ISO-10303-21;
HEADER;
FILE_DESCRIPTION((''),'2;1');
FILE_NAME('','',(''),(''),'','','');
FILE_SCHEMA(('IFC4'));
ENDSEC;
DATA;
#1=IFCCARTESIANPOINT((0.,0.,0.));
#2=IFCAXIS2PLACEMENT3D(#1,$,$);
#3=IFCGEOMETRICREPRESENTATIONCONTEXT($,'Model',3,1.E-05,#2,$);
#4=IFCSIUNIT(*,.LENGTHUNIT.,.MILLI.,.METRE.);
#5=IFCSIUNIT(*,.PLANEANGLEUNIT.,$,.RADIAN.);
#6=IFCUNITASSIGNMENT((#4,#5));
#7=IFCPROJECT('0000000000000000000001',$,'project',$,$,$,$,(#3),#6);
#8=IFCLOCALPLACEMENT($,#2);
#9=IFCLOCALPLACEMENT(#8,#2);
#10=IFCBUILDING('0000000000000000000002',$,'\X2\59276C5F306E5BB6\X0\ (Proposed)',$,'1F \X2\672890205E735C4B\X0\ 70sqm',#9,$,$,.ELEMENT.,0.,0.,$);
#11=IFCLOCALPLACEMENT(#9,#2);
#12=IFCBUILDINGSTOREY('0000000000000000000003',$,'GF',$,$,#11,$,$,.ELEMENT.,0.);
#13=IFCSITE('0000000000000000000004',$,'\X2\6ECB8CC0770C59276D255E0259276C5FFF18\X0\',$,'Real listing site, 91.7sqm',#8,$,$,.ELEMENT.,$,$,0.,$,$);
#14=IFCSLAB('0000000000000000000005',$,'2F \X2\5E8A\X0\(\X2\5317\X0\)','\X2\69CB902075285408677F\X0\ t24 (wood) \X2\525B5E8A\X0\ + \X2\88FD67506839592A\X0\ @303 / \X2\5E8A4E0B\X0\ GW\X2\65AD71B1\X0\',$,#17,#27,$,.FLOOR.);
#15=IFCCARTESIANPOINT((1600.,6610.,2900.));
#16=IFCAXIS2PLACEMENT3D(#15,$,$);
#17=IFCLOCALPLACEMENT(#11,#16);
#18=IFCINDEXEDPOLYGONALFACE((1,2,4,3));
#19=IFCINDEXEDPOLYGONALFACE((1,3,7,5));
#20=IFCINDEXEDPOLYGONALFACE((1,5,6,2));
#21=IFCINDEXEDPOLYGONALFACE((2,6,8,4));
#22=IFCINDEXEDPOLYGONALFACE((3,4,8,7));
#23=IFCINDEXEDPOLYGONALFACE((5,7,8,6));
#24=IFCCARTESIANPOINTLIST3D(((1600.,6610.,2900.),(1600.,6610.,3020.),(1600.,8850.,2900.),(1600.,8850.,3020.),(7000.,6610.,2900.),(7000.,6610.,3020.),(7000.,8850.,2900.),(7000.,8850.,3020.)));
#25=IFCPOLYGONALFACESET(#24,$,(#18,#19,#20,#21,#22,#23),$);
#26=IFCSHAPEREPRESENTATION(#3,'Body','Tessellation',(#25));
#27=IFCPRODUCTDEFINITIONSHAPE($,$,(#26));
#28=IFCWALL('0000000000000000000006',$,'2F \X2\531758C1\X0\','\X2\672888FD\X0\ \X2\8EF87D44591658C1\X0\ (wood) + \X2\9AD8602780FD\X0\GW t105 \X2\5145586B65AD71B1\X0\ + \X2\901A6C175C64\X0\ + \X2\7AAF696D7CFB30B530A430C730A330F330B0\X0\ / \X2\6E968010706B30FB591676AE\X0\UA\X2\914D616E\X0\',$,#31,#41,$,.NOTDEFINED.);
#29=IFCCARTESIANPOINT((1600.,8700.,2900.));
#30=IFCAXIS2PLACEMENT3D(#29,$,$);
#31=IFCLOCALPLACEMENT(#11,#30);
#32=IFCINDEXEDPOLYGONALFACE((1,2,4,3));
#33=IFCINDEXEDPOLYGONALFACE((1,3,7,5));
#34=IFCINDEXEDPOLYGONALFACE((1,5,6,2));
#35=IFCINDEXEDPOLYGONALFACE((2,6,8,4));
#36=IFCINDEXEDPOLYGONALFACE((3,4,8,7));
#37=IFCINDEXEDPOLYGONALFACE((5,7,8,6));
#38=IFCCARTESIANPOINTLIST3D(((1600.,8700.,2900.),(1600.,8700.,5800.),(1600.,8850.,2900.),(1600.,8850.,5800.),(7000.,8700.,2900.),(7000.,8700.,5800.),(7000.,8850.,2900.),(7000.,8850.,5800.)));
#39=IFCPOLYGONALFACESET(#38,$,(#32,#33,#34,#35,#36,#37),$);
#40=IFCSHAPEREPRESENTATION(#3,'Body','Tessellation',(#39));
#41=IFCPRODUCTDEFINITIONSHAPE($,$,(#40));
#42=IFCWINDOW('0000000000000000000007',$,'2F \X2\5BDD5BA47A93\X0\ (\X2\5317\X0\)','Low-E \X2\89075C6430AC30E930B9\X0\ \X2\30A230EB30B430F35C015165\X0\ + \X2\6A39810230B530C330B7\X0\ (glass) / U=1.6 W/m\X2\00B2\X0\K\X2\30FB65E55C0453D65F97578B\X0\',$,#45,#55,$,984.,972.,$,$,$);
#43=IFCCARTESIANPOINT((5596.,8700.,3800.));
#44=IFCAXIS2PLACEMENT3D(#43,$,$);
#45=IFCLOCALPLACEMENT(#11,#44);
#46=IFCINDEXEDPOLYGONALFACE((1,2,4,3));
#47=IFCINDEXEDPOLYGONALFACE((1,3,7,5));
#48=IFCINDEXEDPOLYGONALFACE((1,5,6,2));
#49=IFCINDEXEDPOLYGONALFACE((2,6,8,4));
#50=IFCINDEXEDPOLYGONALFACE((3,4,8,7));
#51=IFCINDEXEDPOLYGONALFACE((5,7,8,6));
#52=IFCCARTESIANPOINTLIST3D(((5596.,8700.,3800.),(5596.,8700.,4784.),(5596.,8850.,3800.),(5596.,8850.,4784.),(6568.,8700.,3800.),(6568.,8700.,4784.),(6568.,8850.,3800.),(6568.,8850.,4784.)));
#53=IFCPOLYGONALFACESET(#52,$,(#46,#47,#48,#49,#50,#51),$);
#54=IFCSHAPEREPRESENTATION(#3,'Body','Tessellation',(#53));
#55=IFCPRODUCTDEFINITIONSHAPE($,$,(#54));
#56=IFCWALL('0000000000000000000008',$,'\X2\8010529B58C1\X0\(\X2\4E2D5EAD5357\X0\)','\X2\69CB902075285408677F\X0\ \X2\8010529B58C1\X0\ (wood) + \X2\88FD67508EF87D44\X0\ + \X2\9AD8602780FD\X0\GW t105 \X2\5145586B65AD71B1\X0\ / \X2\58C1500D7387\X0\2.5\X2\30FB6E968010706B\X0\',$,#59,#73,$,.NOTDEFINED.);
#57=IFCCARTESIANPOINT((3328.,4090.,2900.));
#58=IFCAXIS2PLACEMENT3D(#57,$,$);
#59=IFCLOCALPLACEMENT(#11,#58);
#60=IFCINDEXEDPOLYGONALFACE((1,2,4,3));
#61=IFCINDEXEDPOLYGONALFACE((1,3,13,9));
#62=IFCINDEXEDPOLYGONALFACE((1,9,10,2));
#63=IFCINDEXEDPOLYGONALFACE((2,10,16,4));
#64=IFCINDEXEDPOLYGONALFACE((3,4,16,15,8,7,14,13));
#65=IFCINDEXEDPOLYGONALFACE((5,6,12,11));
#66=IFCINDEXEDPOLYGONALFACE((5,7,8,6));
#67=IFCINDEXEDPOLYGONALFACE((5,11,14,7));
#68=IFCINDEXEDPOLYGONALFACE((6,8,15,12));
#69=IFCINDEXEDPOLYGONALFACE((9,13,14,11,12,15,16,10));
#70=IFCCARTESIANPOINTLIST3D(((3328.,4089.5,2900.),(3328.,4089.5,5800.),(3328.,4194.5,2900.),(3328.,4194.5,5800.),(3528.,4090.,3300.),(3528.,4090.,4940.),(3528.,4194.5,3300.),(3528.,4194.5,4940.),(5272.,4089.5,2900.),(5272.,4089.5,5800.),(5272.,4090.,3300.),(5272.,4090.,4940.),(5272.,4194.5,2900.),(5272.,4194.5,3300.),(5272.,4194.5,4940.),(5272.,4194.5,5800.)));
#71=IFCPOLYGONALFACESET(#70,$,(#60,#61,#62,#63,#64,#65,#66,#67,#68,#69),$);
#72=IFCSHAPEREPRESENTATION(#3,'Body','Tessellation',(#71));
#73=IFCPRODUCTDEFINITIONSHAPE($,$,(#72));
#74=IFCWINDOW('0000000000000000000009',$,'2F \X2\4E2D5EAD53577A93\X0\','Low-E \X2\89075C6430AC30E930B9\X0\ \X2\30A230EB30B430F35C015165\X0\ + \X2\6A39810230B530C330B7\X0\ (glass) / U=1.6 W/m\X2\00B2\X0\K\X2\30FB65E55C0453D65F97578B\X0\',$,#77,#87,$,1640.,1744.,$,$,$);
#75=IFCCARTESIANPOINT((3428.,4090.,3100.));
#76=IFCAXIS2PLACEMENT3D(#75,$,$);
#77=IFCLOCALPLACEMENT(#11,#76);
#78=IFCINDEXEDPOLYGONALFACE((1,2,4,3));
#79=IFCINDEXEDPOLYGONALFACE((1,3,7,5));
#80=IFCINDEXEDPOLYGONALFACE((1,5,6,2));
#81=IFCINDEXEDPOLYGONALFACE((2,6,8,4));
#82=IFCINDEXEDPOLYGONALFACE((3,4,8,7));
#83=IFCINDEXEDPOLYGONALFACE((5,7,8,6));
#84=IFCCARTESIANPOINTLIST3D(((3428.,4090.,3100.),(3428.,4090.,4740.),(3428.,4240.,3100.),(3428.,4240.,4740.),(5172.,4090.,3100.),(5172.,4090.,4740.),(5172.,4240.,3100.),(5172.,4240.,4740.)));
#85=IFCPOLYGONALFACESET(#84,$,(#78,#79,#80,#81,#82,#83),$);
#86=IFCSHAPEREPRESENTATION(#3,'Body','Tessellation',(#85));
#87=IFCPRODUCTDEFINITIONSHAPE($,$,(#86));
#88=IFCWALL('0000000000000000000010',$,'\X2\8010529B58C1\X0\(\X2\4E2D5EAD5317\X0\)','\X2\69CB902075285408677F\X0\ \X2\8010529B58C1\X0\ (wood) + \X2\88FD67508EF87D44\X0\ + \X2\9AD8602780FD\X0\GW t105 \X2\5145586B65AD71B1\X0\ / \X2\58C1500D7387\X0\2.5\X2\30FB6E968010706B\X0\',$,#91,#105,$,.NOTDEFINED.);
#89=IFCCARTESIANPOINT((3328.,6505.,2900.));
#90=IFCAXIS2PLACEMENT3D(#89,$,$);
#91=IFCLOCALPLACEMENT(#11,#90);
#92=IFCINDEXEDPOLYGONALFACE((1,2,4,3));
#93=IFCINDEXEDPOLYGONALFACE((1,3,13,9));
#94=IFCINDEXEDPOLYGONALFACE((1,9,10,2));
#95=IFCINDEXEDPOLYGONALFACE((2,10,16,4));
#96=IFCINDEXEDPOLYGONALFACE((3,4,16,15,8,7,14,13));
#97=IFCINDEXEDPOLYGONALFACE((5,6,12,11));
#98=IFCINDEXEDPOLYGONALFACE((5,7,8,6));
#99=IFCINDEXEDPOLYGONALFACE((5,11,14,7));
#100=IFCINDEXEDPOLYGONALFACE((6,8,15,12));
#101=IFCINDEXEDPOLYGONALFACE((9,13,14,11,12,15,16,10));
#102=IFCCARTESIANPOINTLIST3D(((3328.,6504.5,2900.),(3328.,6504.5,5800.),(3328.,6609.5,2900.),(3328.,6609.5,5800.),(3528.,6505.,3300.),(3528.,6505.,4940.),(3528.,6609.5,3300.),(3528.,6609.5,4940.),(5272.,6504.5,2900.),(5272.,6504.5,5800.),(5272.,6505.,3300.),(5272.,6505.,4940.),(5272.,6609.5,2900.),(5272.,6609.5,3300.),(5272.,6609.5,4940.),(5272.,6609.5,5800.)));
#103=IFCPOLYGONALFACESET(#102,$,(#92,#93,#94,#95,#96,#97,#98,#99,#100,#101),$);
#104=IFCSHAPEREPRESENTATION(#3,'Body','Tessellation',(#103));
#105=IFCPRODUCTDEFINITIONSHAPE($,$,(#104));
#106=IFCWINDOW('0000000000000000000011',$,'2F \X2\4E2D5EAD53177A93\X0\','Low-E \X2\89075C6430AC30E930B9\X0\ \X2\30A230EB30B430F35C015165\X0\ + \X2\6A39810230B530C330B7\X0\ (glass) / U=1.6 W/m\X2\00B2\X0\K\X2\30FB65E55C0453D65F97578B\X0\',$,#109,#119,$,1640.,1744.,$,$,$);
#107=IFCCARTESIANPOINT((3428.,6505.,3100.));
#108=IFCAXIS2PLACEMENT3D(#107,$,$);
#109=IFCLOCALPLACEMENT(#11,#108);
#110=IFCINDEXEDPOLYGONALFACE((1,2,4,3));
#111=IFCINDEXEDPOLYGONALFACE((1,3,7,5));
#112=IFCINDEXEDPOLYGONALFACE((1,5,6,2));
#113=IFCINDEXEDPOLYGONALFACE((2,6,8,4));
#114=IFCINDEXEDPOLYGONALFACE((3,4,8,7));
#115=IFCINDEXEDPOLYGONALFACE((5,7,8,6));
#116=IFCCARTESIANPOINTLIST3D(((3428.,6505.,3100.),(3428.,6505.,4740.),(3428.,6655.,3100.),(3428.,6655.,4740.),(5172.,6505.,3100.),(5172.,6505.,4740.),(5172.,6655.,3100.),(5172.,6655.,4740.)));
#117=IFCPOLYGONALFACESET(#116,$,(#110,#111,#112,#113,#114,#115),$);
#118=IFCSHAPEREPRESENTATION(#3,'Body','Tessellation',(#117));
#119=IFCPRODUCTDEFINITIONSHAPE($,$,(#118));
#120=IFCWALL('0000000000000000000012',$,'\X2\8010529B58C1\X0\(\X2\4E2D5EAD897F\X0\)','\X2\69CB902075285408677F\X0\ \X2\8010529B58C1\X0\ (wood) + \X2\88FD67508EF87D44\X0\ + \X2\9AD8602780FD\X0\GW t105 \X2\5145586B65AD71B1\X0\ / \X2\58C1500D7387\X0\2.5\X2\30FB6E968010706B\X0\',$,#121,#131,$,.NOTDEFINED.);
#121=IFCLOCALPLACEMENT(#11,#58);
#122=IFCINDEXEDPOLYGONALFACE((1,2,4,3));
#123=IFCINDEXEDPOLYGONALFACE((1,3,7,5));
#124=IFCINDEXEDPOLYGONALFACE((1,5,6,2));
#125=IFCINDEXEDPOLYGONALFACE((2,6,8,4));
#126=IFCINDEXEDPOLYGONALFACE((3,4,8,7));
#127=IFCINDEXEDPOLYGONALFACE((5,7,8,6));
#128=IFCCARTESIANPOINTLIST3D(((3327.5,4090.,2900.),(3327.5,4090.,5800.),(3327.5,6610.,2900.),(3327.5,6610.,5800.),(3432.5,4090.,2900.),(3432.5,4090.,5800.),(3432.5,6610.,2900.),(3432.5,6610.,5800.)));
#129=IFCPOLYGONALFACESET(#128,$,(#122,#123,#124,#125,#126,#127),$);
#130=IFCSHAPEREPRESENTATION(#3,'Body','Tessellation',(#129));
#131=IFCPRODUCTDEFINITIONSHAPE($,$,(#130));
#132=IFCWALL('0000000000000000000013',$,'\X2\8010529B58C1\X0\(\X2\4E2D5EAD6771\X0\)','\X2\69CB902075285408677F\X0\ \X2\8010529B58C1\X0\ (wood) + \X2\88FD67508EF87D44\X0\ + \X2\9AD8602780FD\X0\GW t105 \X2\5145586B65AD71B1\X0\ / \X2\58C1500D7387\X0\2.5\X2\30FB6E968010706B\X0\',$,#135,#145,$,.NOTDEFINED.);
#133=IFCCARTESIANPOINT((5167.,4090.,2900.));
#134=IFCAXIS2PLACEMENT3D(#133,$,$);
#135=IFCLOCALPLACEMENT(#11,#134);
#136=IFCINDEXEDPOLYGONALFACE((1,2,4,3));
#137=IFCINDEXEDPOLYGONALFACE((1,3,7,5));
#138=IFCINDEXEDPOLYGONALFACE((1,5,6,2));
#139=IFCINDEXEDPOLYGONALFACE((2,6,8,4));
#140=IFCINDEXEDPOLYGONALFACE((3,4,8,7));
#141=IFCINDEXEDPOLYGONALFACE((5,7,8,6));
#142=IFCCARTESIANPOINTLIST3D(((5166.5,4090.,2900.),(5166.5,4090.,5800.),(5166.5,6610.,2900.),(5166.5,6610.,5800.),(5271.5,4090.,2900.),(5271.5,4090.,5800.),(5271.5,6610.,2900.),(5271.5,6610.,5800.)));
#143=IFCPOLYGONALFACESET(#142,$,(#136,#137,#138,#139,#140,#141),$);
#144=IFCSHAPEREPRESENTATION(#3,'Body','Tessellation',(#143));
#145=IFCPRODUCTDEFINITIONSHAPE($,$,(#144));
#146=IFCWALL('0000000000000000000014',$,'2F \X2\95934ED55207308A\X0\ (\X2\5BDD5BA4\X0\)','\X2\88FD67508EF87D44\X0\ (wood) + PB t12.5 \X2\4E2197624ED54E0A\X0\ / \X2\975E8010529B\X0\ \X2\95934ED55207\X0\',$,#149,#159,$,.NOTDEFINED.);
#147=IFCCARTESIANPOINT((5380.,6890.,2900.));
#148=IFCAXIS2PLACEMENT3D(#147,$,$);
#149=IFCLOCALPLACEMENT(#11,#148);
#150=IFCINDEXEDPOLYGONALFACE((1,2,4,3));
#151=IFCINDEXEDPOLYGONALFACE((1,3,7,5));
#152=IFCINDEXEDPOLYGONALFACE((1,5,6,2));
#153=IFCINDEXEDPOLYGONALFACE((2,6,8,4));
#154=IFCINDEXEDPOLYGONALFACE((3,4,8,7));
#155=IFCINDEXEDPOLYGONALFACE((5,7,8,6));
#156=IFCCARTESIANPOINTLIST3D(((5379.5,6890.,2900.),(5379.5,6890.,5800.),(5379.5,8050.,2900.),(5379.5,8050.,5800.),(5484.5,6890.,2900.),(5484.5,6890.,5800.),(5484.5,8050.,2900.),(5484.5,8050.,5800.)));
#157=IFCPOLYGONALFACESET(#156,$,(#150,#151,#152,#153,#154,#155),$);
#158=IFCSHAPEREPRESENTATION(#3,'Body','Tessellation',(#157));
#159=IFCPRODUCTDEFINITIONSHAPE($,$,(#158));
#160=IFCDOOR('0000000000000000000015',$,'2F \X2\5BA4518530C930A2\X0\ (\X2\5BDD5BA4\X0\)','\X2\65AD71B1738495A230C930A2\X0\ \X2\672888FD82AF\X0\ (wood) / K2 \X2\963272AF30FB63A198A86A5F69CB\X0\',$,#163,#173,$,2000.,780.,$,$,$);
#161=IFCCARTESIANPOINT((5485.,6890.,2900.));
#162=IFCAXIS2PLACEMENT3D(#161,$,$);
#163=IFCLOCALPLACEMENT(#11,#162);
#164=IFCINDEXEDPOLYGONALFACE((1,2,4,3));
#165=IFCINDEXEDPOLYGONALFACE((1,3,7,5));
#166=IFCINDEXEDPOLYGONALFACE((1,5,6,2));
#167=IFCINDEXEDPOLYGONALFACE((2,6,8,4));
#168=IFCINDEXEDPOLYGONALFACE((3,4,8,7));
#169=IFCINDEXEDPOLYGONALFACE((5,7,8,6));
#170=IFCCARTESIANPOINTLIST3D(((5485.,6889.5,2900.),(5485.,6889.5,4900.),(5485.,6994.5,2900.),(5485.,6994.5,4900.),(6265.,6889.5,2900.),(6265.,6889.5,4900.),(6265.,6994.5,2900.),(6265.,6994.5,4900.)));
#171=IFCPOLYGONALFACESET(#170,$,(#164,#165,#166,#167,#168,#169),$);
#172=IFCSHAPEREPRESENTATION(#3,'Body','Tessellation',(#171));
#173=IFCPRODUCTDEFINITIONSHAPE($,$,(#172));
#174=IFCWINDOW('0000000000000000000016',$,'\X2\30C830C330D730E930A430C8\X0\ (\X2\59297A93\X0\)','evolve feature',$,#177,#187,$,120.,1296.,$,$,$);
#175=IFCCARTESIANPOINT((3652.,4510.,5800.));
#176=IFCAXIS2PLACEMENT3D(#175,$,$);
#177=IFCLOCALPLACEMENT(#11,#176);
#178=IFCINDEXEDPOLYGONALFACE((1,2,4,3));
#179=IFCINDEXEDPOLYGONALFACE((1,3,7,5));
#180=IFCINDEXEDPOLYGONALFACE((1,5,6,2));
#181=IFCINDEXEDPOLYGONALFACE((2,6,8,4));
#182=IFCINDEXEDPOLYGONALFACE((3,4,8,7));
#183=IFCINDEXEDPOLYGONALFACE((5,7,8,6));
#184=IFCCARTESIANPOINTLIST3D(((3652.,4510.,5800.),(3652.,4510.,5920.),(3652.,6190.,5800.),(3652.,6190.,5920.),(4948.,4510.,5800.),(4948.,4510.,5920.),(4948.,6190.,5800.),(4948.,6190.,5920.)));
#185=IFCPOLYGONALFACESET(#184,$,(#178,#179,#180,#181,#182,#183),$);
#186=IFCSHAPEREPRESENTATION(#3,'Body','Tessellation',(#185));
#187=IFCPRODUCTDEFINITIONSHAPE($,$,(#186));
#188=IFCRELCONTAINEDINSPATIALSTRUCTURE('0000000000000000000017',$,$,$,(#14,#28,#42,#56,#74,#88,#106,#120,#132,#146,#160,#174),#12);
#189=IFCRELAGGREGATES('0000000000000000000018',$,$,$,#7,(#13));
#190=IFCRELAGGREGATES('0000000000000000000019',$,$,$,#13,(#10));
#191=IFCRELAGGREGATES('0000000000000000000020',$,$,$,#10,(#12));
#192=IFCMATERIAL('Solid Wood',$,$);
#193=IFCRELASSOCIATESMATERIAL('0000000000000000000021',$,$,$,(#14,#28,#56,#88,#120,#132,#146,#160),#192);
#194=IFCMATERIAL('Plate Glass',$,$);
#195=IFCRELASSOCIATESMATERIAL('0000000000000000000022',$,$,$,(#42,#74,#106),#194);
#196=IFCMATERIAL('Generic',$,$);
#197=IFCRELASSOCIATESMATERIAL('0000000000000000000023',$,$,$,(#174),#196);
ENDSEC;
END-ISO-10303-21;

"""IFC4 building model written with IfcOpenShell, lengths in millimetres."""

from ifc_helpers import new_model, si_unit, frame, frame_2d, origin, place, context, project, spatial, rectangle, extrude, material, element, fill, save


model = new_model("IFC4")

# Units and contexts
model_context = context("Model", 3, precision=1e-05, world=origin())
ifc_project = project(units=[si_unit("LENGTHUNIT", "METRE", prefix="MILLI"), si_unit("PLANEANGLEUNIT", "RADIAN")], contexts=[model_context])

# Site, building, storey
site_placement = place(None, origin())
site = spatial("IfcSite", under=ifc_project, at=site_placement, Name="滋賀県大津市大江８", ObjectType="Real listing site, 91.7sqm", CompositionType="ELEMENT", RefElevation=0.0)
building_placement = place(site_placement, origin())
building = spatial("IfcBuilding", under=site, at=building_placement, Name="大江の家 (Proposed)", ObjectType="1F 木造平屋 70sqm", CompositionType="ELEMENT", ElevationOfRefHeight=0.0, ElevationOfTerrain=0.0)
storey_placement = place(building_placement, origin())
storey = spatial("IfcBuildingStorey", under=building, at=storey_placement, Name="GF", CompositionType="ELEMENT", Elevation=0.0)

# Slab
ifc_material_1 = material(Name="Solid Wood")
slab_placement = place(storey_placement, frame((1600.0, 6610.0, 2900.0)))
element("IfcSlab", 1, at=slab_placement, inside=storey, material=ifc_material_1, Name="2F 床(北)", Description="構造用合板 t24 (wood) 剛床 + 製材根太 @303 / 床下 GW断熱", PredefinedType="FLOOR", context=model_context, shape_type="SweptSolid", body=[
    extrude(rectangle(XDim=5400.0, YDim=2240.0, at=frame_2d((2700.0, 1120.0))), frame((1600.0, 6610.0, 2900.0)), (0.0, 0.0, 1.0), 120.0),
])

# Walls, openings, windows
wall_1_placement = place(storey_placement, frame((1600.0, 8700.0, 2900.0)))
wall_1 = element("IfcWall", 2, at=wall_1_placement, inside=storey, material=ifc_material_1, Name="2F 北壁", Description="木製 軸組外壁 (wood) + 高性能GW t105 充填断熱 + 通気層 + 窯業系サイディング / 準耐火・外皮UA配慮", PredefinedType="NOTDEFINED", context=model_context, shape_type="SweptSolid", body=[
    extrude(rectangle(XDim=5400.0, YDim=150.0, at=frame_2d((2700.0, 75.0))), frame((1600.0, 8700.0, 2900.0)), (0.0, 0.0, 1.0), 2900.0),
])
opening_1_placement = place(storey_placement, frame((5596.0, 8700.0, 3800.0)))
opening_1 = element("IfcOpeningElement", 3, at=opening_1_placement, cuts=wall_1, PredefinedType="NOTDEFINED", context=model_context, shape_type="SweptSolid", body=[
    extrude(rectangle(XDim=972.0, YDim=150.0, at=frame_2d((486.0, 75.0))), frame((5596.0, 8700.0, 3800.0)), (0.0, 0.0, 1.0), 984.0),
])
ifc_material_2 = material(Name="Plate Glass")
window_1_placement = place(storey_placement, frame((5596.0, 8700.0, 3800.0)))
window_1 = element("IfcWindow", 4, at=window_1_placement, inside=storey, material=ifc_material_2, Name="2F 寝室窓 (北)", Description="Low-E 複層ガラス アルゴン封入 + 樹脂サッシ (glass) / U=1.6 W/m²K・日射取得型", OverallHeight=984.0, OverallWidth=972.0, context=model_context, shape_type="SweptSolid", body=[
    extrude(rectangle(XDim=972.0, YDim=150.0, at=frame_2d((486.0, 75.0))), frame((5596.0, 8700.0, 3800.0)), (0.0, 0.0, 1.0), 984.0),
])
fill(opening_1, window_1)
wall_2_placement = place(storey_placement, frame((3328.0, 4090.0, 2900.0)))
wall_2 = element("IfcWall", 5, at=wall_2_placement, inside=storey, material=ifc_material_1, Name="耐力壁(中庭南)", Description="構造用合板 耐力壁 (wood) + 製材軸組 + 高性能GW t105 充填断熱 / 壁倍率2.5・準耐火", PredefinedType="NOTDEFINED", context=model_context, shape_type="SweptSolid", body=[
    extrude(rectangle(XDim=1944.0, YDim=105.0, at=frame_2d((972.0, 52.0))), frame((3328.0, 4090.0, 2900.0)), (0.0, 0.0, 1.0), 2900.0),
])
opening_2_placement = place(storey_placement, frame((3428.0, 4090.0, 3100.0)))
opening_2 = element("IfcOpeningElement", 6, at=opening_2_placement, cuts=wall_2, PredefinedType="NOTDEFINED", context=model_context, shape_type="SweptSolid", body=[
    extrude(rectangle(XDim=1744.0, YDim=150.0, at=frame_2d((872.0, 75.0))), frame((3428.0, 4090.0, 3100.0)), (0.0, 0.0, 1.0), 1640.0),
])
window_2_placement = place(storey_placement, frame((3428.0, 4090.0, 3100.0)))
window_2 = element("IfcWindow", 7, at=window_2_placement, inside=storey, material=ifc_material_2, Name="2F 中庭南窓", Description="Low-E 複層ガラス アルゴン封入 + 樹脂サッシ (glass) / U=1.6 W/m²K・日射取得型", OverallHeight=1640.0, OverallWidth=1744.0, context=model_context, shape_type="SweptSolid", body=[
    extrude(rectangle(XDim=1744.0, YDim=150.0, at=frame_2d((872.0, 75.0))), frame((3428.0, 4090.0, 3100.0)), (0.0, 0.0, 1.0), 1640.0),
])
fill(opening_2, window_2)
wall_3_placement = place(storey_placement, frame((3328.0, 6505.0, 2900.0)))
wall_3 = element("IfcWall", 8, at=wall_3_placement, inside=storey, material=ifc_material_1, Name="耐力壁(中庭北)", Description="構造用合板 耐力壁 (wood) + 製材軸組 + 高性能GW t105 充填断熱 / 壁倍率2.5・準耐火", PredefinedType="NOTDEFINED", context=model_context, shape_type="SweptSolid", body=[
    extrude(rectangle(XDim=1944.0, YDim=105.0, at=frame_2d((972.0, 52.0))), frame((3328.0, 6505.0, 2900.0)), (0.0, 0.0, 1.0), 2900.0),
])
opening_3_placement = place(storey_placement, frame((3428.0, 6505.0, 3100.0)))
opening_3 = element("IfcOpeningElement", 9, at=opening_3_placement, cuts=wall_3, PredefinedType="NOTDEFINED", context=model_context, shape_type="SweptSolid", body=[
    extrude(rectangle(XDim=1744.0, YDim=150.0, at=frame_2d((872.0, 75.0))), frame((3428.0, 6505.0, 3100.0)), (0.0, 0.0, 1.0), 1640.0),
])
window_3_placement = place(storey_placement, frame((3428.0, 6505.0, 3100.0)))
window_3 = element("IfcWindow", 10, at=window_3_placement, inside=storey, material=ifc_material_2, Name="2F 中庭北窓", Description="Low-E 複層ガラス アルゴン封入 + 樹脂サッシ (glass) / U=1.6 W/m²K・日射取得型", OverallHeight=1640.0, OverallWidth=1744.0, context=model_context, shape_type="SweptSolid", body=[
    extrude(rectangle(XDim=1744.0, YDim=150.0, at=frame_2d((872.0, 75.0))), frame((3428.0, 6505.0, 3100.0)), (0.0, 0.0, 1.0), 1640.0),
])
fill(opening_3, window_3)

# Walls
wall_4_placement = place(storey_placement, frame((3328.0, 4090.0, 2900.0)))
element("IfcWall", 11, at=wall_4_placement, inside=storey, material=ifc_material_1, Name="耐力壁(中庭西)", Description="構造用合板 耐力壁 (wood) + 製材軸組 + 高性能GW t105 充填断熱 / 壁倍率2.5・準耐火", PredefinedType="NOTDEFINED", context=model_context, shape_type="SweptSolid", body=[
    extrude(rectangle(XDim=105.0, YDim=2520.0, at=frame_2d((52.0, 1260.0))), frame((3328.0, 4090.0, 2900.0)), (0.0, 0.0, 1.0), 2900.0),
])
wall_5_placement = place(storey_placement, frame((5167.0, 4090.0, 2900.0)))
element("IfcWall", 12, at=wall_5_placement, inside=storey, material=ifc_material_1, Name="耐力壁(中庭東)", Description="構造用合板 耐力壁 (wood) + 製材軸組 + 高性能GW t105 充填断熱 / 壁倍率2.5・準耐火", PredefinedType="NOTDEFINED", context=model_context, shape_type="SweptSolid", body=[
    extrude(rectangle(XDim=105.0, YDim=2520.0, at=frame_2d((52.0, 1260.0))), frame((5167.0, 4090.0, 2900.0)), (0.0, 0.0, 1.0), 2900.0),
])
wall_6_placement = place(storey_placement, frame((5380.0, 6890.0, 2900.0)))
element("IfcWall", 13, at=wall_6_placement, inside=storey, material=ifc_material_1, Name="2F 間仕切り (寝室)", Description="製材軸組 (wood) + PB t12.5 両面仕上 / 非耐力 間仕切", PredefinedType="NOTDEFINED", context=model_context, shape_type="SweptSolid", body=[
    extrude(rectangle(XDim=105.0, YDim=1160.0, at=frame_2d((52.0, 580.0))), frame((5380.0, 6890.0, 2900.0)), (0.0, 0.0, 1.0), 2900.0),
])

# Door
door_placement = place(storey_placement, frame((5485.0, 6890.0, 2900.0)))
element("IfcDoor", 14, at=door_placement, inside=storey, material=ifc_material_1, Name="2F 室内ドア (寝室)", Description="断熱玄関ドア 木製芯 (wood) / K2 防犯・採風機構", OverallHeight=2000.0, OverallWidth=780.0, context=model_context, shape_type="SweptSolid", body=[
    extrude(rectangle(XDim=780.0, YDim=105.0, at=frame_2d((390.0, 52.0))), frame((5485.0, 6890.0, 2900.0)), (0.0, 0.0, 1.0), 2000.0),
])

# Window
ifc_material_3 = material(Name="Generic")
window_4_placement = place(storey_placement, frame((3652.0, 4510.0, 5800.0)))
element("IfcWindow", 15, at=window_4_placement, inside=storey, material=ifc_material_3, Name="トップライト (天窓)", Description="evolve feature", OverallHeight=120.0, OverallWidth=1296.0, context=model_context, shape_type="SweptSolid", body=[
    extrude(rectangle(XDim=1296.0, YDim=1680.0, at=frame_2d((648.0, 840.0))), frame((3652.0, 4510.0, 5800.0)), (0.0, 0.0, 1.0), 120.0),
])

save(model, "model.ifc")
